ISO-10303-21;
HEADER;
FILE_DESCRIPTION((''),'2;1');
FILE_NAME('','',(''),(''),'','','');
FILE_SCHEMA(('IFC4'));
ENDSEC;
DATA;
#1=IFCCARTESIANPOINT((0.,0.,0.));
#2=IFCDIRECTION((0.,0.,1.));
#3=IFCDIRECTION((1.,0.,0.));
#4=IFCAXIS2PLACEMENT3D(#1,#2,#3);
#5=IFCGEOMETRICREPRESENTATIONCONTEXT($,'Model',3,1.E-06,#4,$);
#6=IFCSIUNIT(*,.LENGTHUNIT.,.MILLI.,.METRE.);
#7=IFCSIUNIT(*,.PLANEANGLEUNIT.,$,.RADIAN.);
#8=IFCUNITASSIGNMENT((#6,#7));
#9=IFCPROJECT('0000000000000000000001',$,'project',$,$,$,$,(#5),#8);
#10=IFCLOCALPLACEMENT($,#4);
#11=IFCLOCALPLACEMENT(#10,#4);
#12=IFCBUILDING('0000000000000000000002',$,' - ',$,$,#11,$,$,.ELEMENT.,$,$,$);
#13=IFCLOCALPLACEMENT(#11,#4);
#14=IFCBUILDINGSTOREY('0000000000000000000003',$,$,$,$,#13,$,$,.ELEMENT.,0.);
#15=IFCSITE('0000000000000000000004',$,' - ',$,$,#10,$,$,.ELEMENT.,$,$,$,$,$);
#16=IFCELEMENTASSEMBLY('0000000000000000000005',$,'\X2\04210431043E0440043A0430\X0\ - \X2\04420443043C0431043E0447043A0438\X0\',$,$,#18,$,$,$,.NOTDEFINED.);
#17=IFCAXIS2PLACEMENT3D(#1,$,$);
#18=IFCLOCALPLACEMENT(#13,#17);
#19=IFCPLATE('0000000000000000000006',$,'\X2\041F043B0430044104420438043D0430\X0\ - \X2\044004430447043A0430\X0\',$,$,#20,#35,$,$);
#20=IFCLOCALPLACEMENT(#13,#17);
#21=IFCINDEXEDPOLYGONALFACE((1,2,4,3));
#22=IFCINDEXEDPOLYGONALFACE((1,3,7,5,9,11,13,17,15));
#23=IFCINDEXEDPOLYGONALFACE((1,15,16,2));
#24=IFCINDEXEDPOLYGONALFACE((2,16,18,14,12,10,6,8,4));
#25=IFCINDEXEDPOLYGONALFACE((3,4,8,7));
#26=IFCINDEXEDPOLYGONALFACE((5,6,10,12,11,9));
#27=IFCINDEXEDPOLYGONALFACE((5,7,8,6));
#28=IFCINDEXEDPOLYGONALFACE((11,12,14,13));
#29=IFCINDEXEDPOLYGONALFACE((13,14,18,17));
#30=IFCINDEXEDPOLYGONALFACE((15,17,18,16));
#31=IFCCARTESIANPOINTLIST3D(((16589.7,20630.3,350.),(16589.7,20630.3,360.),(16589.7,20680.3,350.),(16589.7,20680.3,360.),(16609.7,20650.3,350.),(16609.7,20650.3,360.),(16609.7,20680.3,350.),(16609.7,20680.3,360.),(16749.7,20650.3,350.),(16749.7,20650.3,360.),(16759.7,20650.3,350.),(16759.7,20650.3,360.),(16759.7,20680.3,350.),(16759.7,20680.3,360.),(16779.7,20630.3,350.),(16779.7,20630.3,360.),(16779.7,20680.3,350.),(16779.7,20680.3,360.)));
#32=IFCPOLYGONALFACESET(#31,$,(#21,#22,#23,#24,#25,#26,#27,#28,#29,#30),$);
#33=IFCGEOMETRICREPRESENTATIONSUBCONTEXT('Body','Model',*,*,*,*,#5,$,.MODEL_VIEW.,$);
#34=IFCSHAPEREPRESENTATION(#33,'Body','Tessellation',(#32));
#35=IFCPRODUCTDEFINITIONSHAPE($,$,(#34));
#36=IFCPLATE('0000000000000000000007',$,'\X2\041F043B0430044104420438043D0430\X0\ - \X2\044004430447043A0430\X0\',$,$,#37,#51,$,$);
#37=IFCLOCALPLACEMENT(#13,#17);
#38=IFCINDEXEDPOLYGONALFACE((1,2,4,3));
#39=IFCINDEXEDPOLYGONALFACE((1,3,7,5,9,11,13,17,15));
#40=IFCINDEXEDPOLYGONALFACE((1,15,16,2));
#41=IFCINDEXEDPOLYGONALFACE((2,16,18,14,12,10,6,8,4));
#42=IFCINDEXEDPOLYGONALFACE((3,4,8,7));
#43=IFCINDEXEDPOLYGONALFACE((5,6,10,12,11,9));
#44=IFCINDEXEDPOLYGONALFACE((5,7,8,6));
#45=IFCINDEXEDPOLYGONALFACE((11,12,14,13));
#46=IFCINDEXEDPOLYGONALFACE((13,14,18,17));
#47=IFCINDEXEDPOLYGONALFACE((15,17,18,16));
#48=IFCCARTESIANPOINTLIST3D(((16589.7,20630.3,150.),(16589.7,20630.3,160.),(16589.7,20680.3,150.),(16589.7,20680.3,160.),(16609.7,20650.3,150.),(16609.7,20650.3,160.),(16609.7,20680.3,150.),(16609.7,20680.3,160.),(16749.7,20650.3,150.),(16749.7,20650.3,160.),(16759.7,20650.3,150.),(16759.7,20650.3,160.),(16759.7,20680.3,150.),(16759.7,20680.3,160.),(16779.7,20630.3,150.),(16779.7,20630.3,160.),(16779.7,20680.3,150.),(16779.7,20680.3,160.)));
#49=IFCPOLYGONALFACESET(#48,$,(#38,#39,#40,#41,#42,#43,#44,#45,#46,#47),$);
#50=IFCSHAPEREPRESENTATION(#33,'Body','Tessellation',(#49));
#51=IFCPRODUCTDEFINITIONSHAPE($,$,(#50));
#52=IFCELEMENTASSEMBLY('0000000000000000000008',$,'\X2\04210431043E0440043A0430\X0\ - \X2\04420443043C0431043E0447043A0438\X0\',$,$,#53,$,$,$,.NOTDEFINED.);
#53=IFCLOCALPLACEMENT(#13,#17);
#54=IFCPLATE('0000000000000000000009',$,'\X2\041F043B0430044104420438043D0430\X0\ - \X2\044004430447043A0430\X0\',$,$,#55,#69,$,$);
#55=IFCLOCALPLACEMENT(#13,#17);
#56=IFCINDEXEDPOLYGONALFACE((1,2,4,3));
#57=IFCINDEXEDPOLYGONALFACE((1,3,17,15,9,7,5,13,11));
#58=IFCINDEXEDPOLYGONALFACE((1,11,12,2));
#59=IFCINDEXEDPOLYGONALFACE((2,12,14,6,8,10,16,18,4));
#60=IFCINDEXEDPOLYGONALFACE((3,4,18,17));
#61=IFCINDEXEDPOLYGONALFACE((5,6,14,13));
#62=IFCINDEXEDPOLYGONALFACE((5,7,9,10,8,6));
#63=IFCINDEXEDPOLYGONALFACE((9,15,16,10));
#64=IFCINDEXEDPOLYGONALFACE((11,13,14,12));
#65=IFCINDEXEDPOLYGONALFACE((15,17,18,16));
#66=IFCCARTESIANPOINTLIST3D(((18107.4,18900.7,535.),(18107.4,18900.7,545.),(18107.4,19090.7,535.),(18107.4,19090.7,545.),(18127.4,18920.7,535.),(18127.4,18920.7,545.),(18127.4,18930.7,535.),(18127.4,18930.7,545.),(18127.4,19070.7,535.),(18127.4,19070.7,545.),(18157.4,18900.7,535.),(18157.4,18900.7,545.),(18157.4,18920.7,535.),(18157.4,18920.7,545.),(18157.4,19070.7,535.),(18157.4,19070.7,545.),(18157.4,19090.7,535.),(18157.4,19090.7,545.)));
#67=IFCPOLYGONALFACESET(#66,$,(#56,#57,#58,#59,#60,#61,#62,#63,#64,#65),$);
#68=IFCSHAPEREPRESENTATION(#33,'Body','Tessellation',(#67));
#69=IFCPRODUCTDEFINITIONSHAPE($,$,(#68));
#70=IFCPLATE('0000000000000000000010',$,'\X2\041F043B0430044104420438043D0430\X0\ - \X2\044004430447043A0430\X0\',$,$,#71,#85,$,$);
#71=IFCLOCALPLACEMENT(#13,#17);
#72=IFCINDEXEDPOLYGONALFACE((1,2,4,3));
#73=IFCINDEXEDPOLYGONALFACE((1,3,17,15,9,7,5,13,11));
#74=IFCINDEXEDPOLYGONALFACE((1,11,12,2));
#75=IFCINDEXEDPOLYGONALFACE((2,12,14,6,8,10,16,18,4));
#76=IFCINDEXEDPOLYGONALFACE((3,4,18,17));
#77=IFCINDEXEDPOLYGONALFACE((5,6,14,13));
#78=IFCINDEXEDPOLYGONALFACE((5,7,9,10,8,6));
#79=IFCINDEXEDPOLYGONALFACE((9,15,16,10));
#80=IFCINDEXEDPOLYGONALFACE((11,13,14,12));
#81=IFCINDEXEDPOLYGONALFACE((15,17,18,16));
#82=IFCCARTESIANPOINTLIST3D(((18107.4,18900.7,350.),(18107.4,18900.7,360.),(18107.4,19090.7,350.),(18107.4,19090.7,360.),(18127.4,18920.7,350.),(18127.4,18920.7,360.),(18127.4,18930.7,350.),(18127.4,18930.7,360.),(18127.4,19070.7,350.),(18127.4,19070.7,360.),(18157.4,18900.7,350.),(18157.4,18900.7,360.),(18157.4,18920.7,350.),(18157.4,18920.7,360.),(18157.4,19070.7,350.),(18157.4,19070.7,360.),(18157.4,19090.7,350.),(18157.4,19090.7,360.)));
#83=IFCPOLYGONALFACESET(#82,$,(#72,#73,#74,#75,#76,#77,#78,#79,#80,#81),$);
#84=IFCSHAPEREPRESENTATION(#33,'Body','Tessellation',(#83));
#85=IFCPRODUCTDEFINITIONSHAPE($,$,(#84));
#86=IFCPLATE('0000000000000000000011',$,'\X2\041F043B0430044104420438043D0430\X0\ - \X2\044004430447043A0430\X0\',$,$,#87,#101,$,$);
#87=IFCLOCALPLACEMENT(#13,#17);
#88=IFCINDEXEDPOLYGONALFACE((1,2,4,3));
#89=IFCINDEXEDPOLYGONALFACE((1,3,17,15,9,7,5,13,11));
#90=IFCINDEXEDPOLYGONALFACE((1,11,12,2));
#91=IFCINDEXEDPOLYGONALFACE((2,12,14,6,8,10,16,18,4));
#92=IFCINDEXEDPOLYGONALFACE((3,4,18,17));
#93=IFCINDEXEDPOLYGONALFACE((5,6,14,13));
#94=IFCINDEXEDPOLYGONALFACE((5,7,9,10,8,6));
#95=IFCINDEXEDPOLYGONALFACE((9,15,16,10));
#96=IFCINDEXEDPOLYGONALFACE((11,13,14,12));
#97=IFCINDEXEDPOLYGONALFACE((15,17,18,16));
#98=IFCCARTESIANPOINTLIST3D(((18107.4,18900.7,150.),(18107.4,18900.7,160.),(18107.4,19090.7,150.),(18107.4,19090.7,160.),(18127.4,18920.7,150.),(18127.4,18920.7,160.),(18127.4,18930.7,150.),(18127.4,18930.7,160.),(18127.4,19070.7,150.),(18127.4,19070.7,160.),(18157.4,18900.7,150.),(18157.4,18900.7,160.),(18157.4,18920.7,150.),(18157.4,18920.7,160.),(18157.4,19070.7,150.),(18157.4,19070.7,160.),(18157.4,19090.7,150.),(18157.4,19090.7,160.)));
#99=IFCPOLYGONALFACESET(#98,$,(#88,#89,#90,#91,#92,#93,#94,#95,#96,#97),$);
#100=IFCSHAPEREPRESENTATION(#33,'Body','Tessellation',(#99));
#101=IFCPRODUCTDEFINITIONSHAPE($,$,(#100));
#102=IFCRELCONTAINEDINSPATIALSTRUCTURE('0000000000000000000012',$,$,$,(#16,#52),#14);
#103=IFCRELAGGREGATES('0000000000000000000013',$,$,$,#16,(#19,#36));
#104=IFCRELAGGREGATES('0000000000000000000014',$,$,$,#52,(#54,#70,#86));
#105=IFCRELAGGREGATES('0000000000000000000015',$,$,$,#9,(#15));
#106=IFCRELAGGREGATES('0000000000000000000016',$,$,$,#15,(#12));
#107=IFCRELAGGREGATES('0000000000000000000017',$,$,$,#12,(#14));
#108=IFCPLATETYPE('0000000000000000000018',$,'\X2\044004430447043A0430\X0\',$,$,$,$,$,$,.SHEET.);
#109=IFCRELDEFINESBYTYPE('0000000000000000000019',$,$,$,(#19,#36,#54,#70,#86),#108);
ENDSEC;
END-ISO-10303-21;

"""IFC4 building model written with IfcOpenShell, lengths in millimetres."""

from ifc_helpers import new_model, si_unit, frame, origin_with_axes, place, context, subcontext, project, spatial, line, indexed_curve, outline, extrude, source, transform, mapped, type_object, element, aggregate, save


model = new_model("IFC4")

# Units and contexts
model_context = context("Model", 3, precision=1e-06, world=origin_with_axes())
body_context = subcontext(model_context, "Body", "Model", "MODEL_VIEW")
ifc_project = project(units=[si_unit("LENGTHUNIT", "METRE", prefix="MILLI"), si_unit("PLANEANGLEUNIT", "RADIAN")], contexts=[model_context])

# Site, building, storey
site_placement = place(None, origin_with_axes())
site = spatial("IfcSite", under=ifc_project, at=site_placement, Name=" - ", CompositionType="ELEMENT")
building_placement = place(site_placement, origin_with_axes())
building = spatial("IfcBuilding", under=site, at=building_placement, Name=" - ", CompositionType="ELEMENT")
storey_placement = place(building_placement, origin_with_axes())
storey = spatial("IfcBuildingStorey", under=building, at=storey_placement, CompositionType="ELEMENT", Elevation=0.0)

# Shared definitions
plate_type = type_object("IfcPlateType", Name="ручка", PredefinedType="SHEET")
shared_shape_1 = source(origin_with_axes(), body_context, "Body", "SweptSolid", [
    extrude(outline(indexed_curve([(-95.0, -25.0), (-75.0, -25.0), (-75.0, 5.0), (-65.0, 5.0), (75.0, 5.0), (75.0, -25.0), (95.0, -25.0), (95.0, 25.0), (-95.0, 25.0)], segments=[line(1, 2), line(2, 3), line(3, 4), line(4, 5), line(5, 6), line(6, 7), line(7, 8), line(8, 9), line(9, 1)])), origin_with_axes(), (0.0, 0.0, 1.0), 10.0),
])

# Element assemblies, plates
assembly_1_placement = place(storey_placement, frame((16484.7, 20680.3, 0.0), z_axis=(0.0, 0.0, 1.0), x_axis=(1.0, 0.0, 0.0)))
assembly_1 = element("IfcElementAssembly", 1, at=assembly_1_placement, inside=storey, Name="Сборка - тумбочки", PredefinedType="NOTDEFINED")
plate_1_placement = place(assembly_1_placement, frame((200.0, -25.0, 350.0), z_axis=(0.0, 0.0, 1.0), x_axis=(-1.0, 0.0, 0.0)))
plate_1 = element("IfcPlate", 2, at=plate_1_placement, type_object=plate_type, Name="Пластина - ручка", context=body_context, shape_type="MappedRepresentation", body=[
    mapped(shared_shape_1, transform((0.0, 0.0, 0.0), x_axis=(1.0, 0.0, 0.0), y_axis=(0.0, 1.0, 0.0), z_axis=(0.0, 0.0, 1.0), scale=1.0)),
])
plate_2_placement = place(assembly_1_placement, frame((200.0, -25.0, 150.0), z_axis=(0.0, 0.0, 1.0), x_axis=(-1.0, 0.0, 0.0)))
plate_2 = element("IfcPlate", 3, at=plate_2_placement, type_object=plate_type, Name="Пластина - ручка", context=body_context, shape_type="MappedRepresentation", body=[
    mapped(shared_shape_1, transform((0.0, 0.0, 0.0), x_axis=(1.0, 0.0, 0.0), y_axis=(0.0, 1.0, 0.0), z_axis=(0.0, 0.0, 1.0), scale=1.0)),
])
aggregate(assembly_1, [plate_1, plate_2])
assembly_2_placement = place(storey_placement, frame((18157.4, 19195.7, 0.0), z_axis=(0.0, 0.0, 1.0), x_axis=(0.0, -1.0, 0.0)))
assembly_2 = element("IfcElementAssembly", 4, at=assembly_2_placement, inside=storey, Name="Сборка - тумбочки", PredefinedType="NOTDEFINED")
plate_3_placement = place(assembly_2_placement, frame((200.0, -25.0, 535.0), z_axis=(0.0, 0.0, 1.0), x_axis=(-1.0, 0.0, 0.0)))
plate_3 = element("IfcPlate", 5, at=plate_3_placement, type_object=plate_type, Name="Пластина - ручка", context=body_context, shape_type="MappedRepresentation", body=[
    mapped(shared_shape_1, transform((0.0, 0.0, 0.0), x_axis=(1.0, 0.0, 0.0), y_axis=(0.0, 1.0, 0.0), z_axis=(0.0, 0.0, 1.0), scale=1.0)),
])
plate_4_placement = place(assembly_2_placement, frame((200.0, -25.0, 350.0), z_axis=(0.0, 0.0, 1.0), x_axis=(-1.0, 0.0, 0.0)))
plate_4 = element("IfcPlate", 6, at=plate_4_placement, type_object=plate_type, Name="Пластина - ручка", context=body_context, shape_type="MappedRepresentation", body=[
    mapped(shared_shape_1, transform((0.0, 0.0, 0.0), x_axis=(1.0, 0.0, 0.0), y_axis=(0.0, 1.0, 0.0), z_axis=(0.0, 0.0, 1.0), scale=1.0)),
])
plate_5_placement = place(assembly_2_placement, frame((200.0, -25.0, 150.0), z_axis=(0.0, 0.0, 1.0), x_axis=(-1.0, 0.0, 0.0)))
plate_5 = element("IfcPlate", 7, at=plate_5_placement, type_object=plate_type, Name="Пластина - ручка", context=body_context, shape_type="MappedRepresentation", body=[
    mapped(shared_shape_1, transform((0.0, 0.0, 0.0), x_axis=(1.0, 0.0, 0.0), y_axis=(0.0, 1.0, 0.0), z_axis=(0.0, 0.0, 1.0), scale=1.0)),
])
aggregate(assembly_2, [plate_3, plate_4, plate_5])

save(model, "model.ifc")
